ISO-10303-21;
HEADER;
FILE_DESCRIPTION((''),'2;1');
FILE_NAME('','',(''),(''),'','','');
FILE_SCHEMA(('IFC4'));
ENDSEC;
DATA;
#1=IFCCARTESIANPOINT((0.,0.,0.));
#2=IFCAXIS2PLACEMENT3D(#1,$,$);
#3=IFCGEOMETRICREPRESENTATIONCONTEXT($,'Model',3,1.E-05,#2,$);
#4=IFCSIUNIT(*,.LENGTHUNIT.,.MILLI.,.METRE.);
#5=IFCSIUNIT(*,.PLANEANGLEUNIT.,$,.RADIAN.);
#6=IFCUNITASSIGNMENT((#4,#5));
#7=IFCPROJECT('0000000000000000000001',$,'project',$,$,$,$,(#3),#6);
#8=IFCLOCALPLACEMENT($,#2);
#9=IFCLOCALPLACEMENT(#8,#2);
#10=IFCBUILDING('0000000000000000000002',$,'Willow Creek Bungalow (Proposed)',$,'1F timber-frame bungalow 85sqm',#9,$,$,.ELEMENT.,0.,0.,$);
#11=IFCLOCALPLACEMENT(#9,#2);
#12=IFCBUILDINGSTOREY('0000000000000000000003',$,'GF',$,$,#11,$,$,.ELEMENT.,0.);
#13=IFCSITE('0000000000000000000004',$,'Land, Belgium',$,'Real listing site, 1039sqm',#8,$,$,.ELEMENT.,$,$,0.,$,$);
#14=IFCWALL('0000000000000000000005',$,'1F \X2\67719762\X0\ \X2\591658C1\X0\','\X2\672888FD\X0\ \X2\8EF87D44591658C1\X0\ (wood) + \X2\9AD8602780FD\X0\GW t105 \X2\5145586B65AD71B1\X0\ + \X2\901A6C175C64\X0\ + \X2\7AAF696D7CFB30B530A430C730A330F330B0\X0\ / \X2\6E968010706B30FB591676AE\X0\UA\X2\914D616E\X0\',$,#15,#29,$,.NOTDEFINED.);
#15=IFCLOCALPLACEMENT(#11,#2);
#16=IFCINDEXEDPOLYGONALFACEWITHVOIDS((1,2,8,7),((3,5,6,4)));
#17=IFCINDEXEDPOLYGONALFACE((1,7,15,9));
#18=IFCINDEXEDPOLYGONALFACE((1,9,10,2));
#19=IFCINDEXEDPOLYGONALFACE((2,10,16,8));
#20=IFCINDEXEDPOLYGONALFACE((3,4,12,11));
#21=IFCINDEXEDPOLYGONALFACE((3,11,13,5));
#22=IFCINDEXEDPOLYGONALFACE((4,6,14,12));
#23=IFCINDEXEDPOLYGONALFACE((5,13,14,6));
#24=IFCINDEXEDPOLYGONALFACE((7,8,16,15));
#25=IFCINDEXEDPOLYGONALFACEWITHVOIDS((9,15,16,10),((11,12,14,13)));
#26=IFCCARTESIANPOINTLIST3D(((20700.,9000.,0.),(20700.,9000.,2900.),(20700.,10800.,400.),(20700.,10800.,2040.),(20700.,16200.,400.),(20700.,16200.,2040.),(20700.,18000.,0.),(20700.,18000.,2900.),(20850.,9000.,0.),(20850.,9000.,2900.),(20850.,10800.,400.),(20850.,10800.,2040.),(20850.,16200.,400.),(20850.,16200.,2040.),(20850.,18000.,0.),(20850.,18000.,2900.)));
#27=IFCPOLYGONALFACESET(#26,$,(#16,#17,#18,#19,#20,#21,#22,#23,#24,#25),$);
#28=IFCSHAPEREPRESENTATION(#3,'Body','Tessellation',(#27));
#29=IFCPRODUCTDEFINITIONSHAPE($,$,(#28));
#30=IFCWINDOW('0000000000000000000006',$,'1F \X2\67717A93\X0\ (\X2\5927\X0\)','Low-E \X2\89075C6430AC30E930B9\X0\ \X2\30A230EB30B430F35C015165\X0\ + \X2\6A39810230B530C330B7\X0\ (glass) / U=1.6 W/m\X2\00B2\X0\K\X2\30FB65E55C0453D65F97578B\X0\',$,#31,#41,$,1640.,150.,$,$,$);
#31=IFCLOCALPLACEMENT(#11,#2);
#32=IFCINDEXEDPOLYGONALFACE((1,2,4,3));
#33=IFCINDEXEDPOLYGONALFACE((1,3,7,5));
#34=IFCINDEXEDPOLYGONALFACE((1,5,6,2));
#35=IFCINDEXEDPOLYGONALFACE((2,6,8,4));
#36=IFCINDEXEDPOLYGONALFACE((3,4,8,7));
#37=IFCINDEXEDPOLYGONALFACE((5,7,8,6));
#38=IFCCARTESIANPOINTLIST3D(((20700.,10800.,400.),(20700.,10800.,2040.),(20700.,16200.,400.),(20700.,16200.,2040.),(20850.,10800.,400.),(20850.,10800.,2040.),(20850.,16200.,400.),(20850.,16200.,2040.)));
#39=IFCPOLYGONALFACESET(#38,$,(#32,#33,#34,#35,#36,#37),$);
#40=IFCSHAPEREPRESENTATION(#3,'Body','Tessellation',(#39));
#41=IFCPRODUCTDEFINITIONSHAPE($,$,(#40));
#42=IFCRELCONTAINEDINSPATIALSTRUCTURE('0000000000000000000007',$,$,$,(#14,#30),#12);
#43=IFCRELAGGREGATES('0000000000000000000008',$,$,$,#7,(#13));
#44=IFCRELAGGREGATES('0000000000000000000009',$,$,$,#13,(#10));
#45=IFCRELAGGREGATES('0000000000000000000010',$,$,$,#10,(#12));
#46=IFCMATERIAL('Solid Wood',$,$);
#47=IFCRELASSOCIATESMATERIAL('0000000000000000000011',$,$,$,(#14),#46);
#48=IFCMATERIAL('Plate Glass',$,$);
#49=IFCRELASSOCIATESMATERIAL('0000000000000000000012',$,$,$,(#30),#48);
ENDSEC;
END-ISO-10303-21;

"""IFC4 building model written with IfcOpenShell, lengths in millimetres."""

from ifc_helpers import new_model, si_unit, frame, frame_2d, origin, place, context, project, spatial, rectangle, extrude, material, element, fill, save


model = new_model("IFC4")

# Units and contexts
model_context = context("Model", 3, precision=1e-05, world=origin())
ifc_project = project(units=[si_unit("LENGTHUNIT", "METRE", prefix="MILLI"), si_unit("PLANEANGLEUNIT", "RADIAN")], contexts=[model_context])

# Site, building, storey
site_placement = place(None, origin())
site = spatial("IfcSite", under=ifc_project, at=site_placement, Name="Land, Belgium", ObjectType="Real listing site, 1039sqm", CompositionType="ELEMENT", RefElevation=0.0)
building_placement = place(site_placement, origin())
building = spatial("IfcBuilding", under=site, at=building_placement, Name="Willow Creek Bungalow (Proposed)", ObjectType="1F timber-frame bungalow 85sqm", CompositionType="ELEMENT", ElevationOfRefHeight=0.0, ElevationOfTerrain=0.0)
storey_placement = place(building_placement, origin())
storey = spatial("IfcBuildingStorey", under=building, at=storey_placement, Name="GF", CompositionType="ELEMENT", Elevation=0.0)

# Shared definitions
ifc_material_1 = material(Name="Solid Wood")

# Wall, opening, window
wall_1_placement = place(storey_placement, frame((10350.0, 4500.0, 0.0)))
wall_1 = element("IfcWall", 1, at=wall_1_placement, inside=storey, material=ifc_material_1, Name="1F 東面 外壁", Description="木製 軸組外壁 (wood) + 高性能GW t105 充填断熱 + 通気層 + 窯業系サイディング / 準耐火・外皮UA配慮", PredefinedType="NOTDEFINED", context=model_context, shape_type="SweptSolid", body=[
    extrude(rectangle(XDim=150.0, YDim=9000.0, at=frame_2d((75.0, 4500.0))), frame((10350.0, 4500.0, 0.0)), (0.0, 0.0, 1.0), 2900.0),
])
opening_1_placement = place(storey_placement, frame((10350.0, 5400.0, 200.0)))
opening_1 = element("IfcOpeningElement", 2, at=opening_1_placement, cuts=wall_1, PredefinedType="NOTDEFINED", context=model_context, shape_type="SweptSolid", body=[
    extrude(rectangle(XDim=150.0, YDim=5400.0, at=frame_2d((75.0, 2700.0))), frame((10350.0, 5400.0, 200.0)), (0.0, 0.0, 1.0), 1640.0),
])
ifc_material_2 = material(Name="Plate Glass")
window_1_placement = place(storey_placement, frame((10350.0, 5400.0, 200.0)))
window_1 = element("IfcWindow", 3, at=window_1_placement, inside=storey, material=ifc_material_2, Name="1F 東窓 (大)", Description="Low-E 複層ガラス アルゴン封入 + 樹脂サッシ (glass) / U=1.6 W/m²K・日射取得型", OverallHeight=1640.0, OverallWidth=150.0, context=model_context, shape_type="SweptSolid", body=[
    extrude(rectangle(XDim=150.0, YDim=5400.0, at=frame_2d((75.0, 2700.0))), frame((10350.0, 5400.0, 200.0)), (0.0, 0.0, 1.0), 1640.0),
])
fill(opening_1, window_1)

save(model, "model.ifc")
